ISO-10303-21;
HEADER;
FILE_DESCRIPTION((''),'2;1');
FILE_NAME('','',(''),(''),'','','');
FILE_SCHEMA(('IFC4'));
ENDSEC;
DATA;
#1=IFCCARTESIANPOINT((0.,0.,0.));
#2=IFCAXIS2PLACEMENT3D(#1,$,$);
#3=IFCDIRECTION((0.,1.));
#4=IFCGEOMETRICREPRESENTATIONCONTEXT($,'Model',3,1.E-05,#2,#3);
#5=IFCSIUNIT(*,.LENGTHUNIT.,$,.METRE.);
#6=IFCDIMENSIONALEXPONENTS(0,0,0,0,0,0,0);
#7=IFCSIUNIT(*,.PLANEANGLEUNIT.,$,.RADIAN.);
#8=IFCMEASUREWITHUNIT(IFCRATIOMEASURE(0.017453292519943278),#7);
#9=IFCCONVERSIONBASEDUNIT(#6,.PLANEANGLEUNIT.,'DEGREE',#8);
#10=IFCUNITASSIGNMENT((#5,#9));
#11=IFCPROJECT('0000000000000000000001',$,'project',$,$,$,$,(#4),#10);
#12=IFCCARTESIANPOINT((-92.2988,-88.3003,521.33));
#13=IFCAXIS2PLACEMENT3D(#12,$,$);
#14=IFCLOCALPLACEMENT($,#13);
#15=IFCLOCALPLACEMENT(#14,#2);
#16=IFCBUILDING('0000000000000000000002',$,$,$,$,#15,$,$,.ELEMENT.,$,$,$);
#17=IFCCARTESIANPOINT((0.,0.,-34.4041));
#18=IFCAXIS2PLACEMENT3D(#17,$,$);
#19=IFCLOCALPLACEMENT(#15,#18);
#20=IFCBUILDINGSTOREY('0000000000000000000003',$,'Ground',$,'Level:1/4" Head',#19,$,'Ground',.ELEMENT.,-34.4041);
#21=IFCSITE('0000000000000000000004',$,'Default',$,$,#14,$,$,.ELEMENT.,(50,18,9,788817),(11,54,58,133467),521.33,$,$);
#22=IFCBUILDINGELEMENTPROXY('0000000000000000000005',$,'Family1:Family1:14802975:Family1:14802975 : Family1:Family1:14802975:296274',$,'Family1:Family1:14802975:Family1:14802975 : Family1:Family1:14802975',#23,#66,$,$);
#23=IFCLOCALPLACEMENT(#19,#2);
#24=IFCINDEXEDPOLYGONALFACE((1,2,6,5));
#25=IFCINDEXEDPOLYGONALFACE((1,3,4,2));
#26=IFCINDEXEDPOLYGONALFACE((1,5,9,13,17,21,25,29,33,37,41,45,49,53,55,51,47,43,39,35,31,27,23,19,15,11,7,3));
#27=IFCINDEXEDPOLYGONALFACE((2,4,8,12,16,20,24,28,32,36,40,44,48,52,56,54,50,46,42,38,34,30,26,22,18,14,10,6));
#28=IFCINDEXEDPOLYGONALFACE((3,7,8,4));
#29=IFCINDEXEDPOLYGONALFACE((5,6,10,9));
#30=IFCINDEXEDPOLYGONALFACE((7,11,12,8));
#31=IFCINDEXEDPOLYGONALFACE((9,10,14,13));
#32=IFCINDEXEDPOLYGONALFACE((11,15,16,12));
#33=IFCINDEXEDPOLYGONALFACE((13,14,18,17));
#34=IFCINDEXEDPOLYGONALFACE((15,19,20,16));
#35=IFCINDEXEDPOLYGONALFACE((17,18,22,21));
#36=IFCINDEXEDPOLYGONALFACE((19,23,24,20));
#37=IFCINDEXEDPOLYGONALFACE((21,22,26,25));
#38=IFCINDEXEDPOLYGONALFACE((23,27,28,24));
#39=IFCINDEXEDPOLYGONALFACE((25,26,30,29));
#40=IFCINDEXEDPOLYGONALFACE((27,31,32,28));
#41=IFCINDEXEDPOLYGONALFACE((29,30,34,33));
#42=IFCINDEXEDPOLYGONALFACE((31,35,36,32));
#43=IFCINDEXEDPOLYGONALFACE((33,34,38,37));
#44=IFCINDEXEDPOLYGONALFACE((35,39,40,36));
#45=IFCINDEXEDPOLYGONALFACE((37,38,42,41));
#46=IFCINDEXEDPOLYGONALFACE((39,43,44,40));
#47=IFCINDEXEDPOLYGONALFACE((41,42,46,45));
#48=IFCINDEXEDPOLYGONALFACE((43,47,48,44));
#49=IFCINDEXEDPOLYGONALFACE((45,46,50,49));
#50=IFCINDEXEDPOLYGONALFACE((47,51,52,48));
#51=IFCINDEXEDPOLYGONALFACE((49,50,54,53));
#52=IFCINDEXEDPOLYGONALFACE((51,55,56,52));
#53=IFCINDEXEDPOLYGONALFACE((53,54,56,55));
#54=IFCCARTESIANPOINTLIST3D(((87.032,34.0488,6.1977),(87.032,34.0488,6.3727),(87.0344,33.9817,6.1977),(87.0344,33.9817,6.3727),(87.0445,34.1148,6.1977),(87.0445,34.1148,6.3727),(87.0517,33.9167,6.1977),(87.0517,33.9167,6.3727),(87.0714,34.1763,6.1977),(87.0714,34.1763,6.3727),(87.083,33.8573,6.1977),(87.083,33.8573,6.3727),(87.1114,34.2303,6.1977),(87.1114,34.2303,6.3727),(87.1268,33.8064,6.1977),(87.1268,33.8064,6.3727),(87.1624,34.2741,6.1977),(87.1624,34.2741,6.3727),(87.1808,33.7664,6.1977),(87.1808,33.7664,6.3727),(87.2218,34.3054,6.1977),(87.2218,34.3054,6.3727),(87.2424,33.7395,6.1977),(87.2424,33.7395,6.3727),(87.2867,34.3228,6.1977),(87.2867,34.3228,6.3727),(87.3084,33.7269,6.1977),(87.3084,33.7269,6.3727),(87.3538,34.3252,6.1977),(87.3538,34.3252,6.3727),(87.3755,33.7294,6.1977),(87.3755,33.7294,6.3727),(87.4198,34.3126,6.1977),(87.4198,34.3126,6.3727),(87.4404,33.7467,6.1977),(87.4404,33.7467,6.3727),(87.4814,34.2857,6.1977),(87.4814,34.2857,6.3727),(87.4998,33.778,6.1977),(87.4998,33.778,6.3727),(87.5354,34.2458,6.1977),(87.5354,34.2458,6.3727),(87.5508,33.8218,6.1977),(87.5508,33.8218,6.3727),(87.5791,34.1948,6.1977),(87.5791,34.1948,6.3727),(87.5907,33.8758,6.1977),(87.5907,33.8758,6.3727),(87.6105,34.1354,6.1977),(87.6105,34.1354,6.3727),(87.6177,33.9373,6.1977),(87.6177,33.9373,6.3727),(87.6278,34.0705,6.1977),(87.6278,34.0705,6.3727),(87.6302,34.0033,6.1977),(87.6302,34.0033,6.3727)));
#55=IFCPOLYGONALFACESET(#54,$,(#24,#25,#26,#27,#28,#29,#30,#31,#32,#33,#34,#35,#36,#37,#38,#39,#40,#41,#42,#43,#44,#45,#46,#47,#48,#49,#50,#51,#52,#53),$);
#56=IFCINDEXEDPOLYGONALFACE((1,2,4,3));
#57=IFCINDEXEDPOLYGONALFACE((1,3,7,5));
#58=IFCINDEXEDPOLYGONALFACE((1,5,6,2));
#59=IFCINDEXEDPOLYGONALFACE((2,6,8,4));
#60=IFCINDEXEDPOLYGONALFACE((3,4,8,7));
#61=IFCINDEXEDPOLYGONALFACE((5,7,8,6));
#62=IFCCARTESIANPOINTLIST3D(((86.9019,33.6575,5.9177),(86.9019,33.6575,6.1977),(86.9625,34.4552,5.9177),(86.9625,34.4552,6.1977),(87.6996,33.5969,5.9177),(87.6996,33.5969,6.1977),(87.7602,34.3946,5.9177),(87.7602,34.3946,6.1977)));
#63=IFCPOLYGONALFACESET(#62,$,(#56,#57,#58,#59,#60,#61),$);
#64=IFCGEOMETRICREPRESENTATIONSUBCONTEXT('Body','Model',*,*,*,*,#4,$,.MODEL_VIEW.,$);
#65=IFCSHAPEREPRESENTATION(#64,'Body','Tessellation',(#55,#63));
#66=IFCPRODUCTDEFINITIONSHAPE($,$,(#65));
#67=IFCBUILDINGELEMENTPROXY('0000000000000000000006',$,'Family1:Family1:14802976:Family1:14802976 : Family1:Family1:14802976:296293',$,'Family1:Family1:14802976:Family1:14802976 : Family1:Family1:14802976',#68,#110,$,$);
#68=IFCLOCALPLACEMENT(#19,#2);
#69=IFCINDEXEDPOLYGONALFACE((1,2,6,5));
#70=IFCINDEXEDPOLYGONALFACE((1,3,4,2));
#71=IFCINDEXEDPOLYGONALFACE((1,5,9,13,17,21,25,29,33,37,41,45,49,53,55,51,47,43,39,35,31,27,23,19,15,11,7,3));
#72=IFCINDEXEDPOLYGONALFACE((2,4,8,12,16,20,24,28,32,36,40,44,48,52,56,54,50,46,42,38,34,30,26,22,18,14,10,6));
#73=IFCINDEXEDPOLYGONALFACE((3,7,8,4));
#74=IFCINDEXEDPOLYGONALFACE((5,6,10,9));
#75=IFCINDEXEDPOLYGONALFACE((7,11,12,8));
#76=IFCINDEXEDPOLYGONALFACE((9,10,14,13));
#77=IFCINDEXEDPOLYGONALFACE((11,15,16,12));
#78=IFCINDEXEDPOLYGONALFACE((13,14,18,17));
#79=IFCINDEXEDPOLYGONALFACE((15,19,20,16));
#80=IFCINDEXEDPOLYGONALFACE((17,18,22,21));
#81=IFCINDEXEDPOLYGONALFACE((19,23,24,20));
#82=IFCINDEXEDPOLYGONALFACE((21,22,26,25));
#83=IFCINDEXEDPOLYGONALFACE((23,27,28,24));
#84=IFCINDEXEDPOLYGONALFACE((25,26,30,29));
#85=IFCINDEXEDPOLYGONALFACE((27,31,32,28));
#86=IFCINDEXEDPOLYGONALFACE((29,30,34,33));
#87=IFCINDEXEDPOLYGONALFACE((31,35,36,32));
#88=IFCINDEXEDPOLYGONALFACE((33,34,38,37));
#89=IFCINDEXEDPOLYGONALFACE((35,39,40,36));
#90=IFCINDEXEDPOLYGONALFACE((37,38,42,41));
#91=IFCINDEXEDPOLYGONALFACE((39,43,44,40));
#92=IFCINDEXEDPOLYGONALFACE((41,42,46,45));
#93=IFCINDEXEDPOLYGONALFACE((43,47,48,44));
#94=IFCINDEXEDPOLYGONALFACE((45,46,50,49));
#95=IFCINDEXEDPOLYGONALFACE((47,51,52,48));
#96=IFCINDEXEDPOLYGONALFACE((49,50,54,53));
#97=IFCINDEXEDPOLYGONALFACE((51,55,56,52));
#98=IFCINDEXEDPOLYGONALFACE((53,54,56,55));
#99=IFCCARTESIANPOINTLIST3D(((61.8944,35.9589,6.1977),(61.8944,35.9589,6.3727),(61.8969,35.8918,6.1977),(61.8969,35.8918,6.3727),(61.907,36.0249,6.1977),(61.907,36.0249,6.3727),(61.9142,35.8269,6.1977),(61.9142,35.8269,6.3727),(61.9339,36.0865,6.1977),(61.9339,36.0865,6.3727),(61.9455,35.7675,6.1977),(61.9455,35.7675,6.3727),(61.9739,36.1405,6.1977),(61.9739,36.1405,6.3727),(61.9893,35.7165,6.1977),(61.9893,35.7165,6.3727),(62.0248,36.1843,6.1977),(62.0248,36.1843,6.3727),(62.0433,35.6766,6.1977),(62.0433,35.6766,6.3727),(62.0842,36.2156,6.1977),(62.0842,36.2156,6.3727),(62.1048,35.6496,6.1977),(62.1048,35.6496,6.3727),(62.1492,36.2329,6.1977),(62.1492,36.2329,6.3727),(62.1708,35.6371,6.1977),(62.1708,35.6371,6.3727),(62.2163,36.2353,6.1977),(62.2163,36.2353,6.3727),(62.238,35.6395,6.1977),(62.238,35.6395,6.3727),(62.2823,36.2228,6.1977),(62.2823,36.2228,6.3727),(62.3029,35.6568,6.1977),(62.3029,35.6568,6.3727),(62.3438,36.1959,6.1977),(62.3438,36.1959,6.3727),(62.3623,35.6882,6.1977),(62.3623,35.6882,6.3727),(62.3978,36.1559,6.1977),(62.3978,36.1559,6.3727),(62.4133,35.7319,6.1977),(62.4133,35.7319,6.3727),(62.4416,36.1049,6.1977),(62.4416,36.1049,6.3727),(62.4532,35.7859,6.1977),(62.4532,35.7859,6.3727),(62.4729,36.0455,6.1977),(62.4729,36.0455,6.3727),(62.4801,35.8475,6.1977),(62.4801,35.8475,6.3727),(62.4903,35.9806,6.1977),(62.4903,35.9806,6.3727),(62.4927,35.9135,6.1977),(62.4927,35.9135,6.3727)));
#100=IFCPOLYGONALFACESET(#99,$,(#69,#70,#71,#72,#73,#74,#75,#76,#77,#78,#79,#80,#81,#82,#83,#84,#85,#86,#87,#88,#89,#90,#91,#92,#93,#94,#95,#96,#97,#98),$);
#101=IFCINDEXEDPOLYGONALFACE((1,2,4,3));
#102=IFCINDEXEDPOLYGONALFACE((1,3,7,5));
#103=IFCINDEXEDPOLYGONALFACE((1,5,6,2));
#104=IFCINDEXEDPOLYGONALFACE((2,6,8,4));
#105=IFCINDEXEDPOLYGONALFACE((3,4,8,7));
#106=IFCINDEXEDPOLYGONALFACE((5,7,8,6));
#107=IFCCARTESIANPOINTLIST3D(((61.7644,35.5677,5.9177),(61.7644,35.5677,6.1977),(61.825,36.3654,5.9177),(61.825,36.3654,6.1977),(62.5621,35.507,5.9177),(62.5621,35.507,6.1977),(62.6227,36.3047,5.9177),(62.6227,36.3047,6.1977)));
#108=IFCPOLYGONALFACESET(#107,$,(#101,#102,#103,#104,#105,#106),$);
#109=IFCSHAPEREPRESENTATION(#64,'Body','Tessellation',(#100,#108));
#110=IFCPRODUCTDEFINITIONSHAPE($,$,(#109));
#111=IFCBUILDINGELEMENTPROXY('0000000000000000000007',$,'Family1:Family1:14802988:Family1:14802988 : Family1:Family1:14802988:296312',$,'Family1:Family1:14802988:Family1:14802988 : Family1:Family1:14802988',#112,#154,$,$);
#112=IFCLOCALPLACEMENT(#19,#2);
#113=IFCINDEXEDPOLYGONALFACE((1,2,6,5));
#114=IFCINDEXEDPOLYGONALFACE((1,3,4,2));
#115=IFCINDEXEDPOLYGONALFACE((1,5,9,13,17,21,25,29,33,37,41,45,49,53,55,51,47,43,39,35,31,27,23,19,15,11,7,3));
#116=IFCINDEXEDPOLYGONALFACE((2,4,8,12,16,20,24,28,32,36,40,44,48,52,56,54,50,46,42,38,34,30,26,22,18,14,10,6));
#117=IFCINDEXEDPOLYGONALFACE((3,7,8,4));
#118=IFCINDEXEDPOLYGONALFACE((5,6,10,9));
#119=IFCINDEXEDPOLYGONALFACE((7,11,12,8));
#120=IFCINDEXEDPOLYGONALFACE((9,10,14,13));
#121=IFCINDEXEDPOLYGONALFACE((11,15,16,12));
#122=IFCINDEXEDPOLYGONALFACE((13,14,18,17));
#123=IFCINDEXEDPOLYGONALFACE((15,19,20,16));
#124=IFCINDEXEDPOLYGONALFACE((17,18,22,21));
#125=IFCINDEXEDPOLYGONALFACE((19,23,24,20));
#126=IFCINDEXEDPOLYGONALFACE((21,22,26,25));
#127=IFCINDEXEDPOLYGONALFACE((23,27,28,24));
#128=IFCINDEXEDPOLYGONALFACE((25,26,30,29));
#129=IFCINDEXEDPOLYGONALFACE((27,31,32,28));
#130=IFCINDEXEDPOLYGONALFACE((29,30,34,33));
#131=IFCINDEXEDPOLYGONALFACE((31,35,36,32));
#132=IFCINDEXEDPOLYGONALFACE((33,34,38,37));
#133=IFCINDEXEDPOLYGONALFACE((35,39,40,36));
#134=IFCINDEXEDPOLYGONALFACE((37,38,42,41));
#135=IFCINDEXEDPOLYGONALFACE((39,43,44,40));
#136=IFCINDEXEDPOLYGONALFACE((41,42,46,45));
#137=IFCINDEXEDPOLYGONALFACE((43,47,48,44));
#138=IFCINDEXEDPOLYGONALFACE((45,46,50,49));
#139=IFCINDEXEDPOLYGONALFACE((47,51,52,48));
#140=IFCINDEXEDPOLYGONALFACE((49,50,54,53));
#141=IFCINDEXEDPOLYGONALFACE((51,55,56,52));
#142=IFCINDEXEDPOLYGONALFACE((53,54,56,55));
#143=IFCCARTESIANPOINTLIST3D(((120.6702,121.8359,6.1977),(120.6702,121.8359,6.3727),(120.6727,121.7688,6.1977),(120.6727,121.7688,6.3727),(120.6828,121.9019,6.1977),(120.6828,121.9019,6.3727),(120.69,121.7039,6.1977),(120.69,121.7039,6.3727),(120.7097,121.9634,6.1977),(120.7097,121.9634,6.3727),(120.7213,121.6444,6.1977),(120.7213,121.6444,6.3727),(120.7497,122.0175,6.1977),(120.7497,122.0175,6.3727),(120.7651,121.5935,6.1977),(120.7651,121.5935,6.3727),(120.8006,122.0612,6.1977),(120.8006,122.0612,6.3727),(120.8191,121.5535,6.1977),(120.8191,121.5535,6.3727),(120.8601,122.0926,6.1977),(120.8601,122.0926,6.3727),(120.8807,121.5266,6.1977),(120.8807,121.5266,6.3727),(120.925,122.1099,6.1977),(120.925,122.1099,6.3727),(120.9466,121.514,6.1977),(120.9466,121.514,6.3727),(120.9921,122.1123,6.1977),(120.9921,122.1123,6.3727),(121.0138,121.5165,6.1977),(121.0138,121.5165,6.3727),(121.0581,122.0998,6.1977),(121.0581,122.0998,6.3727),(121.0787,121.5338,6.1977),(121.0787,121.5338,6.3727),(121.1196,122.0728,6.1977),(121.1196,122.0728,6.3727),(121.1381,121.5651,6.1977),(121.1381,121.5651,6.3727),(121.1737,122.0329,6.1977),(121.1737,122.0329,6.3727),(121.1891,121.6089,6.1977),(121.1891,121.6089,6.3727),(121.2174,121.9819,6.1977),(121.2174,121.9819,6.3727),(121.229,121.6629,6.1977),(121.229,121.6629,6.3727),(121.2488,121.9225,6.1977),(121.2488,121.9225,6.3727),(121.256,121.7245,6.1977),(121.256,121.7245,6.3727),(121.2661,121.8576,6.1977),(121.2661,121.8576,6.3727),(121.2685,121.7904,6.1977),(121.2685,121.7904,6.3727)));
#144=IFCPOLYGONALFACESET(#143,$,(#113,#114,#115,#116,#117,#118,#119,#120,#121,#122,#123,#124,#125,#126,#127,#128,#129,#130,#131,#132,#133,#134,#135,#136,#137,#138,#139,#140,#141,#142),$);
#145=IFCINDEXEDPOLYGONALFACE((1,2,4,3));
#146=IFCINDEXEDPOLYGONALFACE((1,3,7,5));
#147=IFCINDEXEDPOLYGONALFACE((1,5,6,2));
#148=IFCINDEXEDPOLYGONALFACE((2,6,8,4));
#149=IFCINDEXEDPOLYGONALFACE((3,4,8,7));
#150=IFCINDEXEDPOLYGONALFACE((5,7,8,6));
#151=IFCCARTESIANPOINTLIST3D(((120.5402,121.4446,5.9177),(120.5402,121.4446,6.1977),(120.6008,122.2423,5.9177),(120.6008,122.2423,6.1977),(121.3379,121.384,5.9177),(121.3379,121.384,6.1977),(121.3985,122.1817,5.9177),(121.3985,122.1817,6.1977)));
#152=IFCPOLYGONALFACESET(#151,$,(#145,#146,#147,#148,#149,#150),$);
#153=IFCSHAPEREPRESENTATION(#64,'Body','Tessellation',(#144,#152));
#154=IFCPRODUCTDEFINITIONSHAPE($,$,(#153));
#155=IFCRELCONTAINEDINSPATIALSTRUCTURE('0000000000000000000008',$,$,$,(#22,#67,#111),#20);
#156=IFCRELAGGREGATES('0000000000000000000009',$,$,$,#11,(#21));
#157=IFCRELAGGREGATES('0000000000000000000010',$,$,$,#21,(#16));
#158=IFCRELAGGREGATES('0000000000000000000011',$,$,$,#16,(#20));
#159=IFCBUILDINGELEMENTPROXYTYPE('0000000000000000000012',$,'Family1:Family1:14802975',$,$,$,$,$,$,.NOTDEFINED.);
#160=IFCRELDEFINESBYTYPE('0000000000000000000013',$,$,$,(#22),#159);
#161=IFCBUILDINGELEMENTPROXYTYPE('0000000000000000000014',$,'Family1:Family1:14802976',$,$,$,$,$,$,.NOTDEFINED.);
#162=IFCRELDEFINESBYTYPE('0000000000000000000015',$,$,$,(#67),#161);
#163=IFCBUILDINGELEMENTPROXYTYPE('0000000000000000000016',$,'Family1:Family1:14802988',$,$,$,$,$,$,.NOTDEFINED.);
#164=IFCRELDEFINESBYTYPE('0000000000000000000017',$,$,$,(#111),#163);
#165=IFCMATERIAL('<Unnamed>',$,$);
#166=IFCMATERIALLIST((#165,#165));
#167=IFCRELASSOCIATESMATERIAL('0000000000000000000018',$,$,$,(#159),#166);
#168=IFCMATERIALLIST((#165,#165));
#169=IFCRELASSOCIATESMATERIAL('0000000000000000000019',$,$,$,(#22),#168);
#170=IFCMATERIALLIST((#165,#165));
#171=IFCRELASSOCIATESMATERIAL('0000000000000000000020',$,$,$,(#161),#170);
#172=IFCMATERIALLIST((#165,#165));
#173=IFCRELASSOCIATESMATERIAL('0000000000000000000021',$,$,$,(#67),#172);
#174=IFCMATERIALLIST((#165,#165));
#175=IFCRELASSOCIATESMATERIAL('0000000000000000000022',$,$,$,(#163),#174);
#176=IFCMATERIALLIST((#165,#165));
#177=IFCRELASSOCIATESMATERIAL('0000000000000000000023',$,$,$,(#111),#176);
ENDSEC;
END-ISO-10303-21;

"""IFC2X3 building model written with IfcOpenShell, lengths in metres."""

from ifc_helpers import new_model, entity, si_unit, converted_unit, direction, frame, frame_2d, origin, origin_2d_with_axis, place, context, subcontext, project, spatial, rectangle, circle, extrude, source, transform, mapped, material, material_list, type_object, type_shapes, element, save


model = new_model("IFC2X3")

# Units and contexts
model_context = context("Model", 3, precision=1e-05, world=origin(), true_north=direction((0.0, 1.0)))
body_context = subcontext(model_context, "Body", "Model", "MODEL_VIEW")
ifc_project = project(units=[si_unit("LENGTHUNIT", "METRE"), converted_unit("PLANEANGLEUNIT", "DEGREE", entity("IfcRatioMeasure", 0.017453292519943278), si_unit("PLANEANGLEUNIT", "RADIAN"), dimensions=[0, 0, 0, 0, 0, 0, 0])], contexts=[model_context])

# Site, building, storey
site_placement = place(None, frame((-92.2988, -88.3003, 521.33)))
site = spatial("IfcSite", under=ifc_project, at=site_placement, Name="Default", CompositionType="ELEMENT", RefLatitude=(50, 18, 9, 788817), RefLongitude=(11, 54, 58, 133467), RefElevation=521.33)
building_placement = place(site_placement, origin())
building = spatial("IfcBuilding", under=site, at=building_placement, CompositionType="ELEMENT")
storey_placement = place(building_placement, frame((0.0, 0.0, -34.4041)))
storey = spatial("IfcBuildingStorey", under=building, at=storey_placement, Name="Ground", ObjectType="Level:1/4\" Head", LongName="Ground", CompositionType="ELEMENT", Elevation=-34.4041)

# Building element proxies
ifc_material_1 = material(Name="<Unnamed>")
ifc_material_list_1 = material_list([ifc_material_1, ifc_material_1])
ifc_material_list_2 = material_list([ifc_material_1, ifc_material_1])
building_element_proxy_type_1 = type_object("IfcBuildingElementProxyType", Name="Family1:Family1:14802975", PredefinedType="NOTDEFINED", material=ifc_material_list_2)
shared_shape_1 = source(origin(), body_context, "Body", "SweptSolid", [
    extrude(circle(Radius=0.3, at=frame_2d((0.0, 0.0), x_axis=(1.0, 0.0))), frame((87.3311, 34.0261, -28.2064), z_axis=(0.0, 0.0, 1.0), x_axis=(0.997125, -0.07577, 0.0)), (0.0, 0.0, 1.0), 0.175),
    extrude(rectangle(XDim=0.8, YDim=0.8, at=origin_2d_with_axis()), frame((87.3311, 34.0261, -28.4864), z_axis=(0.0, 0.0, 1.0), x_axis=(-0.07577, -0.997125, 0.0)), (0.0, 0.0, 1.0), 0.28),
])
type_shapes(building_element_proxy_type_1, [shared_shape_1])
proxy_1_placement = place(storey_placement, frame((0.0, 0.0, 34.4041)))
element("IfcBuildingElementProxy", 1, at=proxy_1_placement, inside=storey, type_object=building_element_proxy_type_1, material=ifc_material_list_1, Name="Family1:Family1:14802975:Family1:14802975 : Family1:Family1:14802975:296274", ObjectType="Family1:Family1:14802975:Family1:14802975 : Family1:Family1:14802975", context=body_context, shape_type="MappedRepresentation", body=[
    mapped(shared_shape_1, transform((0.0, 0.0, 0.0), scale=1.0)),
])
ifc_material_list_3 = material_list([ifc_material_1, ifc_material_1])
ifc_material_list_4 = material_list([ifc_material_1, ifc_material_1])
building_element_proxy_type_2 = type_object("IfcBuildingElementProxyType", Name="Family1:Family1:14802976", PredefinedType="NOTDEFINED", material=ifc_material_list_4)
shared_shape_2 = source(origin(), body_context, "Body", "SweptSolid", [
    extrude(circle(Radius=0.3, at=frame_2d((0.0, 0.0), x_axis=(1.0, 0.0))), frame((62.1936, 35.9362, -28.2064), z_axis=(0.0, 0.0, 1.0), x_axis=(0.997125, -0.07577, 0.0)), (0.0, 0.0, 1.0), 0.175),
    extrude(rectangle(XDim=0.8, YDim=0.8, at=frame_2d((0.0, 0.0), x_axis=(1.0, 0.0))), frame((62.1936, 35.9362, -28.4864), z_axis=(0.0, 0.0, 1.0), x_axis=(-0.07577, -0.997125, 0.0)), (0.0, 0.0, 1.0), 0.28),
])
type_shapes(building_element_proxy_type_2, [shared_shape_2])
proxy_2_placement = place(storey_placement, frame((0.0, 0.0, 34.4041)))
element("IfcBuildingElementProxy", 2, at=proxy_2_placement, inside=storey, type_object=building_element_proxy_type_2, material=ifc_material_list_3, Name="Family1:Family1:14802976:Family1:14802976 : Family1:Family1:14802976:296293", ObjectType="Family1:Family1:14802976:Family1:14802976 : Family1:Family1:14802976", context=body_context, shape_type="MappedRepresentation", body=[
    mapped(shared_shape_2, transform((0.0, 0.0, 0.0), scale=1.0)),
])
ifc_material_list_5 = material_list([ifc_material_1, ifc_material_1])
ifc_material_list_6 = material_list([ifc_material_1, ifc_material_1])
building_element_proxy_type_3 = type_object("IfcBuildingElementProxyType", Name="Family1:Family1:14802988", PredefinedType="NOTDEFINED", material=ifc_material_list_6)
shared_shape_3 = source(origin(), body_context, "Body", "SweptSolid", [
    extrude(circle(Radius=0.3, at=frame_2d((0.0, 0.0), x_axis=(1.0, 0.0))), frame((120.9694, 121.8132, -28.2064), z_axis=(0.0, 0.0, 1.0), x_axis=(0.997125, -0.07577, 0.0)), (0.0, 0.0, 1.0), 0.175),
    extrude(rectangle(XDim=0.8, YDim=0.8, at=frame_2d((0.0, 0.0), x_axis=(1.0, 0.0))), frame((120.9694, 121.8132, -28.4864), z_axis=(0.0, 0.0, 1.0), x_axis=(-0.07577, -0.997125, 0.0)), (0.0, 0.0, 1.0), 0.28),
])
type_shapes(building_element_proxy_type_3, [shared_shape_3])
proxy_3_placement = place(storey_placement, frame((0.0, 0.0, 34.4041)))
element("IfcBuildingElementProxy", 3, at=proxy_3_placement, inside=storey, type_object=building_element_proxy_type_3, material=ifc_material_list_5, Name="Family1:Family1:14802988:Family1:14802988 : Family1:Family1:14802988:296312", ObjectType="Family1:Family1:14802988:Family1:14802988 : Family1:Family1:14802988", context=body_context, shape_type="MappedRepresentation", body=[
    mapped(shared_shape_3, transform((0.0, 0.0, 0.0), scale=1.0)),
])

save(model, "model.ifc")
